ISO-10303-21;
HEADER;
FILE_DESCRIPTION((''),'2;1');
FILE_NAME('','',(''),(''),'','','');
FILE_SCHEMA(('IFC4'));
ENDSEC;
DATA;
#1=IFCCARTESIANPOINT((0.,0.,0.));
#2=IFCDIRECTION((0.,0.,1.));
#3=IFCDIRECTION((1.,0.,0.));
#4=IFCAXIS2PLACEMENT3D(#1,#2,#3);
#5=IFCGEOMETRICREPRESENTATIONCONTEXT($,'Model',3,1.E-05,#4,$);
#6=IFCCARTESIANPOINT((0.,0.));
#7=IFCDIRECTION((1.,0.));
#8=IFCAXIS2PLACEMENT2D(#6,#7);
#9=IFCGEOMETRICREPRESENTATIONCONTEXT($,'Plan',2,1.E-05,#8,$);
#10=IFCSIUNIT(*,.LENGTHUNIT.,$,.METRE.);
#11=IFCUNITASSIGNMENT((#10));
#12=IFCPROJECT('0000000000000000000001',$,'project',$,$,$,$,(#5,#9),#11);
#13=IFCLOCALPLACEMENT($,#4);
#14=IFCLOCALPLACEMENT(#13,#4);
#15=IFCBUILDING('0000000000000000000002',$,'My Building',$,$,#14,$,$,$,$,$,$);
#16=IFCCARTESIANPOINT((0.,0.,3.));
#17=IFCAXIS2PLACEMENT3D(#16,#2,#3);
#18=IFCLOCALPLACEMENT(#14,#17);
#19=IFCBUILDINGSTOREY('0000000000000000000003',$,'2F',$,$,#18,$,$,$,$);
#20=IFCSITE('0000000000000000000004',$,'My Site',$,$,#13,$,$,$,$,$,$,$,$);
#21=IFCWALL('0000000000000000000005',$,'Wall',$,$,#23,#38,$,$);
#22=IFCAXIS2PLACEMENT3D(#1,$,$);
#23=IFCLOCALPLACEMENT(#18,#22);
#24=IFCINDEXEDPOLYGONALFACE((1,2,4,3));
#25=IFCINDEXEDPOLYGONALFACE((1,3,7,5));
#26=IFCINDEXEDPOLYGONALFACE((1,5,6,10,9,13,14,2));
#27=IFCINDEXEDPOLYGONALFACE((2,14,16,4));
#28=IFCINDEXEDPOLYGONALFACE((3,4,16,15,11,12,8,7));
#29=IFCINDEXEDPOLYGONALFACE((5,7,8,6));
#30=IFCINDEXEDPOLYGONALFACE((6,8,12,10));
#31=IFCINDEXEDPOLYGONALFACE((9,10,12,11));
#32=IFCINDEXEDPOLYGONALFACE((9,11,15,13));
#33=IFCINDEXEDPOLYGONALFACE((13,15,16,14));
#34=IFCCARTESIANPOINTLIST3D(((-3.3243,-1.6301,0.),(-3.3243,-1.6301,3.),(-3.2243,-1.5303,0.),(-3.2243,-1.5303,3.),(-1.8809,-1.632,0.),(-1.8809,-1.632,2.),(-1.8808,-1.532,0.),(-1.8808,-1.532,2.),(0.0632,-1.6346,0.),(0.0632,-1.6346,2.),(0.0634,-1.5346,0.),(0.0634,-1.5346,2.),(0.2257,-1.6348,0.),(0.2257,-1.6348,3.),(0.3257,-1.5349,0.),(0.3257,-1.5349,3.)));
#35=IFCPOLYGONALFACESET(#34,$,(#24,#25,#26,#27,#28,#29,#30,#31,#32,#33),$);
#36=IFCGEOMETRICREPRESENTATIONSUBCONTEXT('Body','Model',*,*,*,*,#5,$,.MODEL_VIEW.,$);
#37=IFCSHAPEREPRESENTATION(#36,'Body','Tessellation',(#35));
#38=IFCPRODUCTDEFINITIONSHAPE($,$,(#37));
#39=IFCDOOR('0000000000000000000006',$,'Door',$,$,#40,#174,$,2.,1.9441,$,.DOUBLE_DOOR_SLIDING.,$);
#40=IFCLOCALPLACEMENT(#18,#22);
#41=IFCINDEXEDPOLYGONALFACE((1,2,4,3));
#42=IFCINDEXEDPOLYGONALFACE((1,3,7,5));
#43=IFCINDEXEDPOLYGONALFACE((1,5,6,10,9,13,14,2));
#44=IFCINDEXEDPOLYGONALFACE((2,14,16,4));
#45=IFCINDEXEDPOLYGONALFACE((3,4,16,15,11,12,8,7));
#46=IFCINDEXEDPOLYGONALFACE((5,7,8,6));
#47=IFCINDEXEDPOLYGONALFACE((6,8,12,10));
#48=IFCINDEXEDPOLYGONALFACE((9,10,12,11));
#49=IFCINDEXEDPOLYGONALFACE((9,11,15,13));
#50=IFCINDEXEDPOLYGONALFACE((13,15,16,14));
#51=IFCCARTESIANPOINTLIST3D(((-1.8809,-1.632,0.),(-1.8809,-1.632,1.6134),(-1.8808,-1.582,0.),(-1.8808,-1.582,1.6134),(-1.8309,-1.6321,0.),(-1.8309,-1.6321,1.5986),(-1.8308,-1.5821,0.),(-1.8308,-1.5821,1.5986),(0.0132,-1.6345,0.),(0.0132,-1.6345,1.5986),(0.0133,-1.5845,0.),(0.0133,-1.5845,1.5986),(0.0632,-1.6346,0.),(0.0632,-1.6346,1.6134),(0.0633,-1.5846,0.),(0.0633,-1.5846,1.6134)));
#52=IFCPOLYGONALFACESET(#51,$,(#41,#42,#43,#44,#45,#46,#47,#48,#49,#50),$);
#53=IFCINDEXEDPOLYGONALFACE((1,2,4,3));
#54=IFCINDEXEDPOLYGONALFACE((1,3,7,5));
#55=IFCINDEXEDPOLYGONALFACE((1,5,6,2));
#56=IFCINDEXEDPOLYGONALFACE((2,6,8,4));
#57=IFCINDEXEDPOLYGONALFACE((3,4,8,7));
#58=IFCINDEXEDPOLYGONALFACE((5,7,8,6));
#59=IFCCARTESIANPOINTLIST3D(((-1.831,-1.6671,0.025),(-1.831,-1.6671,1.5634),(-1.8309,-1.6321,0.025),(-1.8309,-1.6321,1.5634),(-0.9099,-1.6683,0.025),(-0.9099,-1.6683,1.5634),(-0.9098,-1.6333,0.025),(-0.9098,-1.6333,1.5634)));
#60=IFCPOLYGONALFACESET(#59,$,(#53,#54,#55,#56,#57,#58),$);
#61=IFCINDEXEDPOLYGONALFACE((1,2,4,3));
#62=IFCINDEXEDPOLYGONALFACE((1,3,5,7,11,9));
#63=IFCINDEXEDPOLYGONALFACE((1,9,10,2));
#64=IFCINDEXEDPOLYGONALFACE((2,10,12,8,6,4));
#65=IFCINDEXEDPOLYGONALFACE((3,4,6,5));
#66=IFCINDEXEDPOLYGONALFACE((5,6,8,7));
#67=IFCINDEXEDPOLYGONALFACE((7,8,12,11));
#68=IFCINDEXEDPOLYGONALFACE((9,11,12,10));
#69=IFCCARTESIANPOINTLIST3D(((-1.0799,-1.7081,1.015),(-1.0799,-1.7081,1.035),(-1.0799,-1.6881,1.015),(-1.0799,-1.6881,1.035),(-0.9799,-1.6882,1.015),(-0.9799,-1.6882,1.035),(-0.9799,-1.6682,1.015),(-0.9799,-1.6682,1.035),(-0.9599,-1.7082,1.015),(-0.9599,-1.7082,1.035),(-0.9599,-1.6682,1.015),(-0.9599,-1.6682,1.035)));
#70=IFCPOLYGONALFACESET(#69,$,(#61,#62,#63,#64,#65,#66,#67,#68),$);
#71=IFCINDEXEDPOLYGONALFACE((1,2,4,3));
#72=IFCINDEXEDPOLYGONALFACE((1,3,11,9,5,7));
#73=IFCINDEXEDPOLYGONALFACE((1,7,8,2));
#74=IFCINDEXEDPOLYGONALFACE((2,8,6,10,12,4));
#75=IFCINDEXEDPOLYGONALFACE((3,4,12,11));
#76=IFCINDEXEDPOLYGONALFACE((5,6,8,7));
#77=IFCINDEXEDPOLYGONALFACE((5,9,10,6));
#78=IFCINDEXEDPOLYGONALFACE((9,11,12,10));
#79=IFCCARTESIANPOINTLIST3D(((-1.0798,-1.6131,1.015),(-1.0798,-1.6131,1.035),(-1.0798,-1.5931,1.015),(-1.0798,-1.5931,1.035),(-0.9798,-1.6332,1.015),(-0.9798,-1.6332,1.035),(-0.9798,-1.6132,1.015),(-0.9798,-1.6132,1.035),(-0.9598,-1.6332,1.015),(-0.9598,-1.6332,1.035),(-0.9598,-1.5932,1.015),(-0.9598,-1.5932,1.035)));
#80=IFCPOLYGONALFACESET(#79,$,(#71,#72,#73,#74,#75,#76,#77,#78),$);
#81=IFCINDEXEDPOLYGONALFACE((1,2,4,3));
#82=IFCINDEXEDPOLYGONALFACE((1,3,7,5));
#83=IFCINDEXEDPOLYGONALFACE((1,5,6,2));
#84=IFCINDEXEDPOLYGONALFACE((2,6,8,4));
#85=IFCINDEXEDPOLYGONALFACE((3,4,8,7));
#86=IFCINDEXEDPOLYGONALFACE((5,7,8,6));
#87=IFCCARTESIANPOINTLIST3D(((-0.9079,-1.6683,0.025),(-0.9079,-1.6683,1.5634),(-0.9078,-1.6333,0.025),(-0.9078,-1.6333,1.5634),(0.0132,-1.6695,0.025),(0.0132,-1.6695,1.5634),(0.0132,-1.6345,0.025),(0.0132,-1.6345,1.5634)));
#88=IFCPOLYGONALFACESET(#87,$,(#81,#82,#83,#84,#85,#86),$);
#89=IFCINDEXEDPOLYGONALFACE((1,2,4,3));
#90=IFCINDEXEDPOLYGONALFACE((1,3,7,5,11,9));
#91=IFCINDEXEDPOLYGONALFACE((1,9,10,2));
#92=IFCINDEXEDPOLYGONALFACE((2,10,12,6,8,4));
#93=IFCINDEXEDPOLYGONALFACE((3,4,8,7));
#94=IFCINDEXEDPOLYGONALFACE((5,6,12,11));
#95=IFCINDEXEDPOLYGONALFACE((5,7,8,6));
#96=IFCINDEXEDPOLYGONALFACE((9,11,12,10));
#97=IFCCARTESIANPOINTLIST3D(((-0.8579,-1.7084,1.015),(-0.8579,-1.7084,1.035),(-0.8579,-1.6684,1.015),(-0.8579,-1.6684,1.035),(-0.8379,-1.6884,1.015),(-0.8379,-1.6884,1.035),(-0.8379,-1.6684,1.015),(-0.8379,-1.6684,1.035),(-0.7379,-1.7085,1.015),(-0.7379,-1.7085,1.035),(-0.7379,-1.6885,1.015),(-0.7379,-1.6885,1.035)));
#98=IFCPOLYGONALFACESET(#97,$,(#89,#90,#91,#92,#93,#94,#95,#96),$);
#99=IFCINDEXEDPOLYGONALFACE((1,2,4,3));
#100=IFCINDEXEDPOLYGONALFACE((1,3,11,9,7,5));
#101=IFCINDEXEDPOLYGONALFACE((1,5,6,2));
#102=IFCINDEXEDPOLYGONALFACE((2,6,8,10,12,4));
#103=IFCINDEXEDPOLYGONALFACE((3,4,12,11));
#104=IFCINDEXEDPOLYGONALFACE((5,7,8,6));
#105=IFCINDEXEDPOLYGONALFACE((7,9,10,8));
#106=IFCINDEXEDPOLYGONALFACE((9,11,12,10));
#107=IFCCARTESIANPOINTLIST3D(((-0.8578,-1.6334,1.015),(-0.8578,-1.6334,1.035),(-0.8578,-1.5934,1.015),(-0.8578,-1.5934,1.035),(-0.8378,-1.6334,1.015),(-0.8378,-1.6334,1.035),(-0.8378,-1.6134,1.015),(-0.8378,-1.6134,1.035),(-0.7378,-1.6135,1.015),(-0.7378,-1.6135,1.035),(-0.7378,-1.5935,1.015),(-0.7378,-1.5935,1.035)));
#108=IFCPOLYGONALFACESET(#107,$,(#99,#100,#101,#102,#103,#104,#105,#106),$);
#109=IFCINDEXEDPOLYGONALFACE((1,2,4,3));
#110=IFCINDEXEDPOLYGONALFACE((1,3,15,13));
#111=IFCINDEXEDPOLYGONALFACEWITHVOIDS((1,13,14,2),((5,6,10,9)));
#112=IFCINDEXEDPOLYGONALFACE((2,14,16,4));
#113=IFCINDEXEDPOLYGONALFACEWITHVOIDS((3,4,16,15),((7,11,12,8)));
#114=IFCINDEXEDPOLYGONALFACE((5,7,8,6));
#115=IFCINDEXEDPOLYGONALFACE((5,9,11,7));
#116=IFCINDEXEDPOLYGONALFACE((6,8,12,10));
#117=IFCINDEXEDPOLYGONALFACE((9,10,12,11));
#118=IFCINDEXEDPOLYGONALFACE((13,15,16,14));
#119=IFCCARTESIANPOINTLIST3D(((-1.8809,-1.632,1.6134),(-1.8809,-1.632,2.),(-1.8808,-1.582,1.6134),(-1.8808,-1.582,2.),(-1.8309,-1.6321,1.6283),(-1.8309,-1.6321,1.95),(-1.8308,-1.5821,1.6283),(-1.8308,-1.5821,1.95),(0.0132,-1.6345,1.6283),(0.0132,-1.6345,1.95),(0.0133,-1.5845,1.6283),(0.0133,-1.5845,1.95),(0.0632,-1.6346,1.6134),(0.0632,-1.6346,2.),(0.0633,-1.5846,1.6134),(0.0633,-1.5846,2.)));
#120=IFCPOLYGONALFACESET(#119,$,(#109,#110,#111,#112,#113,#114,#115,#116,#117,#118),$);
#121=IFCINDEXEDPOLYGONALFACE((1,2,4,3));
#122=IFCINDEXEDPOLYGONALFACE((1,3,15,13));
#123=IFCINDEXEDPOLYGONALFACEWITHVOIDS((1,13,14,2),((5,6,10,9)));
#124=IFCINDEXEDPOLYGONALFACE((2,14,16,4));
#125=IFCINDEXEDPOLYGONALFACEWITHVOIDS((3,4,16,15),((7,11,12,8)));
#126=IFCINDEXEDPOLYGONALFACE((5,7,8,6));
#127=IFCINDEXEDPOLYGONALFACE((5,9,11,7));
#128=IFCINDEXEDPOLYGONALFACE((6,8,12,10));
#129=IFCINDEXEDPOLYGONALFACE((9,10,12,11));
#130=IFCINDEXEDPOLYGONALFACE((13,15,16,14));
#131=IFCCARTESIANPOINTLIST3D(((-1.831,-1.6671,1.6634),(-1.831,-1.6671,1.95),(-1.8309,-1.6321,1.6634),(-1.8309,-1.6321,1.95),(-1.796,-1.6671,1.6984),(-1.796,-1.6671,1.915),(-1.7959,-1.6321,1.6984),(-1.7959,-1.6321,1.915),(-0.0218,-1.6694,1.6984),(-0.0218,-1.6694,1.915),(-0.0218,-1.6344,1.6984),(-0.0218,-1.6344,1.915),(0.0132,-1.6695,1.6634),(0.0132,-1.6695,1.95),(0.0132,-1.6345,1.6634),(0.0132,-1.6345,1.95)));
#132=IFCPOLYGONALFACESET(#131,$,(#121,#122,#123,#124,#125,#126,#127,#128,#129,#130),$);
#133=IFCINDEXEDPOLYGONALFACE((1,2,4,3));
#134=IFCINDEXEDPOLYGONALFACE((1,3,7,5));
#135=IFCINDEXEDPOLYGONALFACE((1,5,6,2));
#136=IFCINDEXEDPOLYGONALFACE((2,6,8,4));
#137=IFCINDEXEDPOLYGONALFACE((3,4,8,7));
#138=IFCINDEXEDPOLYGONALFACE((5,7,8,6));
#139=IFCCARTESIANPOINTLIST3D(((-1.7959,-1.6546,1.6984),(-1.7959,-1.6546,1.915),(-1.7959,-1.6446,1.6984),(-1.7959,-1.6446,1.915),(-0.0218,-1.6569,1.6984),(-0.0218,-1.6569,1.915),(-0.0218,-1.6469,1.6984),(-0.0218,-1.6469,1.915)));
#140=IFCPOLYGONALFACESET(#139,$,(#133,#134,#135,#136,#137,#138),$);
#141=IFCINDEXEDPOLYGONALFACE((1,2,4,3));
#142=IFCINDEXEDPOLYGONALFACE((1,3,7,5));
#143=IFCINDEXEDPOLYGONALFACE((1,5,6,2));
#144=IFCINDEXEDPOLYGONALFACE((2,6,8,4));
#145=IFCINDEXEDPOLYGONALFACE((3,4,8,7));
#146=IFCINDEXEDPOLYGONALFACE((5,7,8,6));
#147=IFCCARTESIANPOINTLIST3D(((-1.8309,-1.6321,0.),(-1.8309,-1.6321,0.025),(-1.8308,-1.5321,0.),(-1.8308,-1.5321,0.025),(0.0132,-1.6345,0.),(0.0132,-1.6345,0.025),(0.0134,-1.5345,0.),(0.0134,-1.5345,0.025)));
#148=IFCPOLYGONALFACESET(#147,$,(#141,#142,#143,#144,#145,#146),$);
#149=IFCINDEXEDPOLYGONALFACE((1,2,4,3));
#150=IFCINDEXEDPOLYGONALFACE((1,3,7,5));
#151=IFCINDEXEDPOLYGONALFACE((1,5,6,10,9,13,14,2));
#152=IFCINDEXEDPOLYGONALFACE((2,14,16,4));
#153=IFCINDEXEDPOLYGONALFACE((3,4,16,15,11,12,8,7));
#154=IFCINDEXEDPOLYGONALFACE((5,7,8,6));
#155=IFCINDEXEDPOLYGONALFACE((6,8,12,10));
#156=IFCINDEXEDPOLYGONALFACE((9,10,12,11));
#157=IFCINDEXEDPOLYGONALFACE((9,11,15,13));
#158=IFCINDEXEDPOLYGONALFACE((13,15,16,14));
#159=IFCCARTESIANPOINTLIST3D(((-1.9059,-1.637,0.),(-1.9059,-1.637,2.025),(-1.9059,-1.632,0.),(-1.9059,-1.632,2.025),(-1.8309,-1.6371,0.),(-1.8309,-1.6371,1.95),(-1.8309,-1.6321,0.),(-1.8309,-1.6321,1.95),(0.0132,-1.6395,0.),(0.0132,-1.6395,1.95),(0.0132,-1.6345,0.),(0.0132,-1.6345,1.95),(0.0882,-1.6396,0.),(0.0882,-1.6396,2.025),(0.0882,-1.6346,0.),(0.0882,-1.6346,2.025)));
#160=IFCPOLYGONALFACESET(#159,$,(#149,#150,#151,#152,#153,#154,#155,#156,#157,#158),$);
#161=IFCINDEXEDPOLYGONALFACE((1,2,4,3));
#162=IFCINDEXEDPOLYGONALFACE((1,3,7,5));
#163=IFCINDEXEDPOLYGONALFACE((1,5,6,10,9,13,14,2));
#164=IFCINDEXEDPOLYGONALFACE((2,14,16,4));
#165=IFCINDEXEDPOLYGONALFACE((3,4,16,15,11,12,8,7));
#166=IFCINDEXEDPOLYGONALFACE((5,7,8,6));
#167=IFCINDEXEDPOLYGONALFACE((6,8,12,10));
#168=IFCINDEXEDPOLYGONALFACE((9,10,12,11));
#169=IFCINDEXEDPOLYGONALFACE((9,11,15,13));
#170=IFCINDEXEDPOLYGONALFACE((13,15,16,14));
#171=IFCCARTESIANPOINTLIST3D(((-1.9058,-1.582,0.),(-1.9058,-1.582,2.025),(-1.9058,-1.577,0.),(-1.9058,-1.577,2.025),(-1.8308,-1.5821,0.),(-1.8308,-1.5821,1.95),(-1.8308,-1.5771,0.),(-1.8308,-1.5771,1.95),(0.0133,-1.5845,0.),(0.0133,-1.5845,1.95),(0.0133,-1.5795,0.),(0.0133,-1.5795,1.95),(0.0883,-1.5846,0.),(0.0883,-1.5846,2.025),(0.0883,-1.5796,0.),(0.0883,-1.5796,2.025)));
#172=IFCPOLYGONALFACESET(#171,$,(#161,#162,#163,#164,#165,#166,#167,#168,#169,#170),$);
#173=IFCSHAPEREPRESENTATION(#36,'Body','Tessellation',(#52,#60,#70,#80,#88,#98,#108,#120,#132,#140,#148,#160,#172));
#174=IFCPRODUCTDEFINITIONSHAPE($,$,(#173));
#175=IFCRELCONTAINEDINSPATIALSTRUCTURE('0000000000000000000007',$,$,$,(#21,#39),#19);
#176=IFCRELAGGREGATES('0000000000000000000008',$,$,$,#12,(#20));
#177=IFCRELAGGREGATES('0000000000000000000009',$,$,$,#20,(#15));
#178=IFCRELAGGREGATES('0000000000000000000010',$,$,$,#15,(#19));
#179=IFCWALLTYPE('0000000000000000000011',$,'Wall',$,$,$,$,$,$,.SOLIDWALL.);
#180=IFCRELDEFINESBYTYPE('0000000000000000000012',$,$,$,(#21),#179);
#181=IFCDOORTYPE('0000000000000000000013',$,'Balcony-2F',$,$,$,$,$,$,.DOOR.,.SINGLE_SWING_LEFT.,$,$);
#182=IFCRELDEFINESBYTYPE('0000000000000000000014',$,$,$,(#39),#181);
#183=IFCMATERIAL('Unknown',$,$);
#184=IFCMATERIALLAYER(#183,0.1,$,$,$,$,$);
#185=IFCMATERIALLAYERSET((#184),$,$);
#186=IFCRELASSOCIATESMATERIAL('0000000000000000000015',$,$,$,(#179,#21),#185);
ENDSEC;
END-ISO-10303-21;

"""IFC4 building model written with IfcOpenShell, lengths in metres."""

from ifc_helpers import new_model, entity, si_unit, frame, origin_with_axes, origin_2d_with_axis, place, context, subcontext, project, spatial, line, indexed_curve, outline, extrude, shape, source, transform, mapped, material, layer, layer_set, layer_usage, type_object, type_shapes, element, fill, save


model = new_model("IFC4")

# Units and contexts
model_context = context("Model", 3, precision=1e-05, world=origin_with_axes())
plan_context = context("Plan", 2, precision=1e-05, world=origin_2d_with_axis())
body_context_1 = subcontext(model_context, "Body", "Model", "MODEL_VIEW")
body_context_2 = subcontext(plan_context, "Body", "Plan", "PLAN_VIEW")
ifc_project = project(units=[si_unit("LENGTHUNIT", "METRE")], contexts=[model_context, plan_context])

# Site, building, storey
site_placement = place(None, origin_with_axes())
site = spatial("IfcSite", under=ifc_project, at=site_placement, Name="My Site")
building_placement = place(site_placement, origin_with_axes())
building = spatial("IfcBuilding", under=site, at=building_placement, Name="My Building")
storey_placement = place(building_placement, frame((0.0, 0.0, 3.0), z_axis=(0.0, 0.0, 1.0), x_axis=(1.0, 0.0, 0.0)))
storey = spatial("IfcBuildingStorey", under=building, at=storey_placement, Name="2F")

# Shared definitions
ifc_material = material(Name="Unknown")
ifc_layer = layer(ifc_material, 0.1)
ifc_layer_set = layer_set([ifc_layer])
wall_type = type_object("IfcWallType", Name="Wall", PredefinedType="SOLIDWALL", material=ifc_layer_set)

# Wall, opening, door
ifc_layer_usage_1 = layer_usage(ifc_layer_set, "AXIS2", "POSITIVE", 0.0)
wall_1_placement = place(storey_placement, frame((-3.3243, -1.6301, 0.0), z_axis=(0.0, 0.0, 1.0), x_axis=(0.999999, -0.001304, 0.0)))
wall_1 = element("IfcWall", 1, at=wall_1_placement, inside=storey, type_object=wall_type, material=ifc_layer_usage_1, Name="Wall", context=body_context_1, shape_type="SweptSolid", body=[
    extrude(outline(indexed_curve([(0.0, 0.0), (0.0999, 0.1), (3.6499, 0.1), (3.55, 0.0)], segments=[line(1, 2, 3, 4, 1)])), origin_with_axes(), (0.0, 0.0, 1.0), 3.0),
])
shared_shape_1 = source(origin_with_axes(), body_context_1, "Body", "SweptSolid", [
    extrude(outline(indexed_curve([(0.0, 0.0), (1.9441, 0.0), (1.9441, 2.0), (0.0, 2.0)], segments=[line(1, 2, 3, 4, 1)])), frame((0.0, -0.6, 0.0), z_axis=(0.0, -1.0, 0.0), x_axis=(1.0, 0.0, 0.0)), (0.0, 0.0, -1.0), 1.2),
])
opening_1_placement = place(wall_1_placement, frame((1.4434, 0.0, 0.0), z_axis=(0.0, 0.0, 1.0), x_axis=(1.0, 0.0, 0.0)))
opening_1 = element("IfcOpeningElement", 2, at=opening_1_placement, cuts=wall_1, PredefinedType="OPENING", context=body_context_1, shape_type="MappedRepresentation", body=[
    mapped(shared_shape_1, transform((0.0, 0.0, 0.0), x_axis=(1.0, 0.0, 0.0), y_axis=(0.0, 1.0, 0.0), z_axis=(0.0, 0.0, 1.0), scale=1.0)),
])
door_type_1 = type_object("IfcDoorType", Name="Balcony-2F", OperationType="SINGLE_SWING_LEFT", PredefinedType="DOOR")
shared_shape_2 = source(origin_with_axes(), body_context_1, "Body", "SweptSolid", [
    extrude(outline(indexed_curve([(0.0, 0.0), (0.0, 1.6134), (1.9441, 1.6134), (1.9441, 0.0), (1.8941, 0.0), (1.8941, 1.5986), (0.05, 1.5986), (0.05, 0.0)], segments=[line(1, 2, 3, 4, 5, 6, 7, 8, 1)])), frame((0.0, 0.0, 0.0), z_axis=(0.0, -1.0, 0.0), x_axis=(1.0, 0.0, 0.0)), (0.0, 0.0, -1.0), 0.05),
    extrude(outline(indexed_curve([(0.0, 0.0), (0.9211, 0.0), (0.9211, 0.035), (0.0, 0.035)], segments=[line(1, 2, 3, 4, 1)])), frame((0.05, -0.035, 0.025), z_axis=(0.0, 0.0, 1.0), x_axis=(1.0, 0.0, 0.0)), (0.0, 0.0, 1.0), 1.5384),
    extrude(outline(indexed_curve([(0.0, 0.0), (0.0, -0.04), (-0.12, -0.04), (-0.12, -0.02), (-0.02, -0.02), (-0.02, 0.0)], segments=[line(1, 2, 3, 4, 5, 6, 1)])), frame((0.9211, -0.035, 1.015), z_axis=(0.0, 0.0, 1.0), x_axis=(1.0, 0.0, 0.0)), (0.0, 0.0, 1.0), 0.02),
    extrude(outline(indexed_curve([(0.0, 0.0), (0.0, 0.04), (-0.12, 0.04), (-0.12, 0.02), (-0.02, 0.02), (-0.02, 0.0)], segments=[line(1, 2, 3, 4, 5, 6, 1)])), frame((0.9211, 0.0, 1.015), z_axis=(0.0, 0.0, 1.0), x_axis=(1.0, 0.0, 0.0)), (0.0, 0.0, 1.0), 0.02),
    extrude(outline(indexed_curve([(0.0, 0.0), (-0.9211, 0.0), (-0.9211, 0.035), (0.0, 0.035)], segments=[line(1, 2, 3, 4, 1)])), frame((1.8941, -0.035, 0.025), z_axis=(0.0, 0.0, 1.0), x_axis=(1.0, 0.0, 0.0)), (0.0, 0.0, 1.0), 1.5384),
    extrude(outline(indexed_curve([(0.0, 0.0), (0.0, -0.04), (0.12, -0.04), (0.12, -0.02), (0.02, -0.02), (0.02, 0.0)], segments=[line(1, 2, 3, 4, 5, 6, 1)])), frame((1.0231, -0.035, 1.015), z_axis=(0.0, 0.0, 1.0), x_axis=(1.0, 0.0, 0.0)), (0.0, 0.0, 1.0), 0.02),
    extrude(outline(indexed_curve([(0.0, 0.0), (0.0, 0.04), (0.12, 0.04), (0.12, 0.02), (0.02, 0.02), (0.02, 0.0)], segments=[line(1, 2, 3, 4, 5, 6, 1)])), frame((1.0231, 0.0, 1.015), z_axis=(0.0, 0.0, 1.0), x_axis=(1.0, 0.0, 0.0)), (0.0, 0.0, 1.0), 0.02),
    extrude(outline(indexed_curve([(0.0, 0.0), (1.9441, 0.0), (1.9441, 0.3866), (0.0, 0.3866)], segments=[line(1, 2, 3, 4, 1)]), holes=[indexed_curve([(0.05, 0.0148), (1.8941, 0.0148), (1.8941, 0.3366), (0.05, 0.3366)], segments=[line(1, 2, 3, 4, 1)])]), frame((0.0, 0.0, 1.6134), z_axis=(0.0, -1.0, 0.0), x_axis=(1.0, 0.0, 0.0)), (0.0, 0.0, -1.0), 0.05),
    extrude(outline(indexed_curve([(0.0, 0.0), (1.8441, 0.0), (1.8441, 0.2866), (0.0, 0.2866)], segments=[line(1, 2, 3, 4, 1)]), holes=[indexed_curve([(0.035, 0.035), (1.8091, 0.035), (1.8091, 0.2516), (0.035, 0.2516)], segments=[line(1, 2, 3, 4, 1)])]), frame((0.05, -0.035, 1.6634), z_axis=(0.0, -1.0, 0.0), x_axis=(1.0, 0.0, 0.0)), (0.0, 0.0, -1.0), 0.035),
    extrude(outline(indexed_curve([(0.035, 0.035), (1.8091, 0.035), (1.8091, 0.2516), (0.035, 0.2516)], segments=[line(1, 2, 3, 4, 1)])), frame((0.05, -0.0225, 1.6634), z_axis=(0.0, -1.0, 0.0), x_axis=(1.0, 0.0, 0.0)), (0.0, 0.0, -1.0), 0.01),
    extrude(outline(indexed_curve([(0.0, 0.0), (1.8441, 0.0), (1.8441, 0.1), (0.0, 0.1)], segments=[line(1, 2, 3, 4, 1)])), frame((0.05, 0.0, 0.0), z_axis=(0.0, 0.0, 1.0), x_axis=(1.0, 0.0, 0.0)), (0.0, 0.0, 1.0), 0.025),
    extrude(outline(indexed_curve([(0.0, 0.0), (0.0, 2.025), (1.9941, 2.025), (1.9941, 0.0), (1.9191, 0.0), (1.9191, 1.95), (0.075, 1.95), (0.075, 0.0)], segments=[line(1, 2, 3, 4, 5, 6, 7, 8, 1)])), frame((-0.025, -0.005, 0.0), z_axis=(0.0, -1.0, 0.0), x_axis=(1.0, 0.0, 0.0)), (0.0, 0.0, -1.0), 0.005),
    extrude(outline(indexed_curve([(0.0, 0.0), (0.0, 2.025), (1.9941, 2.025), (1.9941, 0.0), (1.9191, 0.0), (1.9191, 1.95), (0.075, 1.95), (0.075, 0.0)], segments=[line(1, 2, 3, 4, 5, 6, 7, 8, 1)])), frame((-0.025, 0.05, 0.0), z_axis=(0.0, -1.0, 0.0), x_axis=(1.0, 0.0, 0.0)), (0.0, 0.0, -1.0), 0.005),
])
shared_shape_3 = source(origin_with_axes(), body_context_2, "Body", "Curve2D", [
    entity("IfcIndexedPolyCurve", entity("IfcCartesianPointList2D", [[0.0, 0.0], [0.05, 0.0], [0.05, 0.05], [0.0, 0.05]]), [entity("IfcLineIndex", [1, 2, 3, 4, 1])]),
    entity("IfcIndexedPolyCurve", entity("IfcCartesianPointList2D", [[1.9441, 0.0], [1.8941, 0.0], [1.8941, 0.05], [1.9441, 0.05]]), [entity("IfcLineIndex", [1, 2, 3, 4, 1])]),
    entity("IfcIndexedPolyCurve", entity("IfcCartesianPointList2D", [[-0.411, -0.035], [0.511, -0.035], [0.511, 0.0], [-0.411, 0.0]]), [entity("IfcLineIndex", [1, 2, 3, 4, 1])]),
    entity("IfcIndexedPolyCurve", entity("IfcCartesianPointList2D", [[2.3552, -0.035], [1.4331, -0.035], [1.4331, 0.0], [2.3552, 0.0]]), [entity("IfcLineIndex", [1, 2, 3, 4, 1])]),
])
type_shapes(door_type_1, [shared_shape_2, shared_shape_3])
door_1_placement = place(opening_1_placement, frame((0.0, 0.0, 0.0), z_axis=(0.0, 0.0, 1.0), x_axis=(1.0, 0.0, 0.0)))
door_1 = element("IfcDoor", 3, at=door_1_placement, inside=storey, type_object=door_type_1, Name="Door", OperationType="DOUBLE_DOOR_SLIDING", OverallHeight=2.0, OverallWidth=1.9441, shapes=[
    shape(body_context_1, "Body", "MappedRepresentation", [mapped(shared_shape_2, transform((0.0, 0.0, 0.0), x_axis=(1.0, 0.0, 0.0), y_axis=(0.0, 1.0, 0.0), z_axis=(0.0, 0.0, 1.0), scale=1.0))]),
    shape(body_context_2, "Body", "MappedRepresentation", [mapped(shared_shape_3, transform((0.0, 0.0, 0.0), x_axis=(1.0, 0.0, 0.0), y_axis=(0.0, 1.0, 0.0), z_axis=(0.0, 0.0, 1.0), scale=1.0))]),
])
fill(opening_1, door_1)

save(model, "model.ifc")
